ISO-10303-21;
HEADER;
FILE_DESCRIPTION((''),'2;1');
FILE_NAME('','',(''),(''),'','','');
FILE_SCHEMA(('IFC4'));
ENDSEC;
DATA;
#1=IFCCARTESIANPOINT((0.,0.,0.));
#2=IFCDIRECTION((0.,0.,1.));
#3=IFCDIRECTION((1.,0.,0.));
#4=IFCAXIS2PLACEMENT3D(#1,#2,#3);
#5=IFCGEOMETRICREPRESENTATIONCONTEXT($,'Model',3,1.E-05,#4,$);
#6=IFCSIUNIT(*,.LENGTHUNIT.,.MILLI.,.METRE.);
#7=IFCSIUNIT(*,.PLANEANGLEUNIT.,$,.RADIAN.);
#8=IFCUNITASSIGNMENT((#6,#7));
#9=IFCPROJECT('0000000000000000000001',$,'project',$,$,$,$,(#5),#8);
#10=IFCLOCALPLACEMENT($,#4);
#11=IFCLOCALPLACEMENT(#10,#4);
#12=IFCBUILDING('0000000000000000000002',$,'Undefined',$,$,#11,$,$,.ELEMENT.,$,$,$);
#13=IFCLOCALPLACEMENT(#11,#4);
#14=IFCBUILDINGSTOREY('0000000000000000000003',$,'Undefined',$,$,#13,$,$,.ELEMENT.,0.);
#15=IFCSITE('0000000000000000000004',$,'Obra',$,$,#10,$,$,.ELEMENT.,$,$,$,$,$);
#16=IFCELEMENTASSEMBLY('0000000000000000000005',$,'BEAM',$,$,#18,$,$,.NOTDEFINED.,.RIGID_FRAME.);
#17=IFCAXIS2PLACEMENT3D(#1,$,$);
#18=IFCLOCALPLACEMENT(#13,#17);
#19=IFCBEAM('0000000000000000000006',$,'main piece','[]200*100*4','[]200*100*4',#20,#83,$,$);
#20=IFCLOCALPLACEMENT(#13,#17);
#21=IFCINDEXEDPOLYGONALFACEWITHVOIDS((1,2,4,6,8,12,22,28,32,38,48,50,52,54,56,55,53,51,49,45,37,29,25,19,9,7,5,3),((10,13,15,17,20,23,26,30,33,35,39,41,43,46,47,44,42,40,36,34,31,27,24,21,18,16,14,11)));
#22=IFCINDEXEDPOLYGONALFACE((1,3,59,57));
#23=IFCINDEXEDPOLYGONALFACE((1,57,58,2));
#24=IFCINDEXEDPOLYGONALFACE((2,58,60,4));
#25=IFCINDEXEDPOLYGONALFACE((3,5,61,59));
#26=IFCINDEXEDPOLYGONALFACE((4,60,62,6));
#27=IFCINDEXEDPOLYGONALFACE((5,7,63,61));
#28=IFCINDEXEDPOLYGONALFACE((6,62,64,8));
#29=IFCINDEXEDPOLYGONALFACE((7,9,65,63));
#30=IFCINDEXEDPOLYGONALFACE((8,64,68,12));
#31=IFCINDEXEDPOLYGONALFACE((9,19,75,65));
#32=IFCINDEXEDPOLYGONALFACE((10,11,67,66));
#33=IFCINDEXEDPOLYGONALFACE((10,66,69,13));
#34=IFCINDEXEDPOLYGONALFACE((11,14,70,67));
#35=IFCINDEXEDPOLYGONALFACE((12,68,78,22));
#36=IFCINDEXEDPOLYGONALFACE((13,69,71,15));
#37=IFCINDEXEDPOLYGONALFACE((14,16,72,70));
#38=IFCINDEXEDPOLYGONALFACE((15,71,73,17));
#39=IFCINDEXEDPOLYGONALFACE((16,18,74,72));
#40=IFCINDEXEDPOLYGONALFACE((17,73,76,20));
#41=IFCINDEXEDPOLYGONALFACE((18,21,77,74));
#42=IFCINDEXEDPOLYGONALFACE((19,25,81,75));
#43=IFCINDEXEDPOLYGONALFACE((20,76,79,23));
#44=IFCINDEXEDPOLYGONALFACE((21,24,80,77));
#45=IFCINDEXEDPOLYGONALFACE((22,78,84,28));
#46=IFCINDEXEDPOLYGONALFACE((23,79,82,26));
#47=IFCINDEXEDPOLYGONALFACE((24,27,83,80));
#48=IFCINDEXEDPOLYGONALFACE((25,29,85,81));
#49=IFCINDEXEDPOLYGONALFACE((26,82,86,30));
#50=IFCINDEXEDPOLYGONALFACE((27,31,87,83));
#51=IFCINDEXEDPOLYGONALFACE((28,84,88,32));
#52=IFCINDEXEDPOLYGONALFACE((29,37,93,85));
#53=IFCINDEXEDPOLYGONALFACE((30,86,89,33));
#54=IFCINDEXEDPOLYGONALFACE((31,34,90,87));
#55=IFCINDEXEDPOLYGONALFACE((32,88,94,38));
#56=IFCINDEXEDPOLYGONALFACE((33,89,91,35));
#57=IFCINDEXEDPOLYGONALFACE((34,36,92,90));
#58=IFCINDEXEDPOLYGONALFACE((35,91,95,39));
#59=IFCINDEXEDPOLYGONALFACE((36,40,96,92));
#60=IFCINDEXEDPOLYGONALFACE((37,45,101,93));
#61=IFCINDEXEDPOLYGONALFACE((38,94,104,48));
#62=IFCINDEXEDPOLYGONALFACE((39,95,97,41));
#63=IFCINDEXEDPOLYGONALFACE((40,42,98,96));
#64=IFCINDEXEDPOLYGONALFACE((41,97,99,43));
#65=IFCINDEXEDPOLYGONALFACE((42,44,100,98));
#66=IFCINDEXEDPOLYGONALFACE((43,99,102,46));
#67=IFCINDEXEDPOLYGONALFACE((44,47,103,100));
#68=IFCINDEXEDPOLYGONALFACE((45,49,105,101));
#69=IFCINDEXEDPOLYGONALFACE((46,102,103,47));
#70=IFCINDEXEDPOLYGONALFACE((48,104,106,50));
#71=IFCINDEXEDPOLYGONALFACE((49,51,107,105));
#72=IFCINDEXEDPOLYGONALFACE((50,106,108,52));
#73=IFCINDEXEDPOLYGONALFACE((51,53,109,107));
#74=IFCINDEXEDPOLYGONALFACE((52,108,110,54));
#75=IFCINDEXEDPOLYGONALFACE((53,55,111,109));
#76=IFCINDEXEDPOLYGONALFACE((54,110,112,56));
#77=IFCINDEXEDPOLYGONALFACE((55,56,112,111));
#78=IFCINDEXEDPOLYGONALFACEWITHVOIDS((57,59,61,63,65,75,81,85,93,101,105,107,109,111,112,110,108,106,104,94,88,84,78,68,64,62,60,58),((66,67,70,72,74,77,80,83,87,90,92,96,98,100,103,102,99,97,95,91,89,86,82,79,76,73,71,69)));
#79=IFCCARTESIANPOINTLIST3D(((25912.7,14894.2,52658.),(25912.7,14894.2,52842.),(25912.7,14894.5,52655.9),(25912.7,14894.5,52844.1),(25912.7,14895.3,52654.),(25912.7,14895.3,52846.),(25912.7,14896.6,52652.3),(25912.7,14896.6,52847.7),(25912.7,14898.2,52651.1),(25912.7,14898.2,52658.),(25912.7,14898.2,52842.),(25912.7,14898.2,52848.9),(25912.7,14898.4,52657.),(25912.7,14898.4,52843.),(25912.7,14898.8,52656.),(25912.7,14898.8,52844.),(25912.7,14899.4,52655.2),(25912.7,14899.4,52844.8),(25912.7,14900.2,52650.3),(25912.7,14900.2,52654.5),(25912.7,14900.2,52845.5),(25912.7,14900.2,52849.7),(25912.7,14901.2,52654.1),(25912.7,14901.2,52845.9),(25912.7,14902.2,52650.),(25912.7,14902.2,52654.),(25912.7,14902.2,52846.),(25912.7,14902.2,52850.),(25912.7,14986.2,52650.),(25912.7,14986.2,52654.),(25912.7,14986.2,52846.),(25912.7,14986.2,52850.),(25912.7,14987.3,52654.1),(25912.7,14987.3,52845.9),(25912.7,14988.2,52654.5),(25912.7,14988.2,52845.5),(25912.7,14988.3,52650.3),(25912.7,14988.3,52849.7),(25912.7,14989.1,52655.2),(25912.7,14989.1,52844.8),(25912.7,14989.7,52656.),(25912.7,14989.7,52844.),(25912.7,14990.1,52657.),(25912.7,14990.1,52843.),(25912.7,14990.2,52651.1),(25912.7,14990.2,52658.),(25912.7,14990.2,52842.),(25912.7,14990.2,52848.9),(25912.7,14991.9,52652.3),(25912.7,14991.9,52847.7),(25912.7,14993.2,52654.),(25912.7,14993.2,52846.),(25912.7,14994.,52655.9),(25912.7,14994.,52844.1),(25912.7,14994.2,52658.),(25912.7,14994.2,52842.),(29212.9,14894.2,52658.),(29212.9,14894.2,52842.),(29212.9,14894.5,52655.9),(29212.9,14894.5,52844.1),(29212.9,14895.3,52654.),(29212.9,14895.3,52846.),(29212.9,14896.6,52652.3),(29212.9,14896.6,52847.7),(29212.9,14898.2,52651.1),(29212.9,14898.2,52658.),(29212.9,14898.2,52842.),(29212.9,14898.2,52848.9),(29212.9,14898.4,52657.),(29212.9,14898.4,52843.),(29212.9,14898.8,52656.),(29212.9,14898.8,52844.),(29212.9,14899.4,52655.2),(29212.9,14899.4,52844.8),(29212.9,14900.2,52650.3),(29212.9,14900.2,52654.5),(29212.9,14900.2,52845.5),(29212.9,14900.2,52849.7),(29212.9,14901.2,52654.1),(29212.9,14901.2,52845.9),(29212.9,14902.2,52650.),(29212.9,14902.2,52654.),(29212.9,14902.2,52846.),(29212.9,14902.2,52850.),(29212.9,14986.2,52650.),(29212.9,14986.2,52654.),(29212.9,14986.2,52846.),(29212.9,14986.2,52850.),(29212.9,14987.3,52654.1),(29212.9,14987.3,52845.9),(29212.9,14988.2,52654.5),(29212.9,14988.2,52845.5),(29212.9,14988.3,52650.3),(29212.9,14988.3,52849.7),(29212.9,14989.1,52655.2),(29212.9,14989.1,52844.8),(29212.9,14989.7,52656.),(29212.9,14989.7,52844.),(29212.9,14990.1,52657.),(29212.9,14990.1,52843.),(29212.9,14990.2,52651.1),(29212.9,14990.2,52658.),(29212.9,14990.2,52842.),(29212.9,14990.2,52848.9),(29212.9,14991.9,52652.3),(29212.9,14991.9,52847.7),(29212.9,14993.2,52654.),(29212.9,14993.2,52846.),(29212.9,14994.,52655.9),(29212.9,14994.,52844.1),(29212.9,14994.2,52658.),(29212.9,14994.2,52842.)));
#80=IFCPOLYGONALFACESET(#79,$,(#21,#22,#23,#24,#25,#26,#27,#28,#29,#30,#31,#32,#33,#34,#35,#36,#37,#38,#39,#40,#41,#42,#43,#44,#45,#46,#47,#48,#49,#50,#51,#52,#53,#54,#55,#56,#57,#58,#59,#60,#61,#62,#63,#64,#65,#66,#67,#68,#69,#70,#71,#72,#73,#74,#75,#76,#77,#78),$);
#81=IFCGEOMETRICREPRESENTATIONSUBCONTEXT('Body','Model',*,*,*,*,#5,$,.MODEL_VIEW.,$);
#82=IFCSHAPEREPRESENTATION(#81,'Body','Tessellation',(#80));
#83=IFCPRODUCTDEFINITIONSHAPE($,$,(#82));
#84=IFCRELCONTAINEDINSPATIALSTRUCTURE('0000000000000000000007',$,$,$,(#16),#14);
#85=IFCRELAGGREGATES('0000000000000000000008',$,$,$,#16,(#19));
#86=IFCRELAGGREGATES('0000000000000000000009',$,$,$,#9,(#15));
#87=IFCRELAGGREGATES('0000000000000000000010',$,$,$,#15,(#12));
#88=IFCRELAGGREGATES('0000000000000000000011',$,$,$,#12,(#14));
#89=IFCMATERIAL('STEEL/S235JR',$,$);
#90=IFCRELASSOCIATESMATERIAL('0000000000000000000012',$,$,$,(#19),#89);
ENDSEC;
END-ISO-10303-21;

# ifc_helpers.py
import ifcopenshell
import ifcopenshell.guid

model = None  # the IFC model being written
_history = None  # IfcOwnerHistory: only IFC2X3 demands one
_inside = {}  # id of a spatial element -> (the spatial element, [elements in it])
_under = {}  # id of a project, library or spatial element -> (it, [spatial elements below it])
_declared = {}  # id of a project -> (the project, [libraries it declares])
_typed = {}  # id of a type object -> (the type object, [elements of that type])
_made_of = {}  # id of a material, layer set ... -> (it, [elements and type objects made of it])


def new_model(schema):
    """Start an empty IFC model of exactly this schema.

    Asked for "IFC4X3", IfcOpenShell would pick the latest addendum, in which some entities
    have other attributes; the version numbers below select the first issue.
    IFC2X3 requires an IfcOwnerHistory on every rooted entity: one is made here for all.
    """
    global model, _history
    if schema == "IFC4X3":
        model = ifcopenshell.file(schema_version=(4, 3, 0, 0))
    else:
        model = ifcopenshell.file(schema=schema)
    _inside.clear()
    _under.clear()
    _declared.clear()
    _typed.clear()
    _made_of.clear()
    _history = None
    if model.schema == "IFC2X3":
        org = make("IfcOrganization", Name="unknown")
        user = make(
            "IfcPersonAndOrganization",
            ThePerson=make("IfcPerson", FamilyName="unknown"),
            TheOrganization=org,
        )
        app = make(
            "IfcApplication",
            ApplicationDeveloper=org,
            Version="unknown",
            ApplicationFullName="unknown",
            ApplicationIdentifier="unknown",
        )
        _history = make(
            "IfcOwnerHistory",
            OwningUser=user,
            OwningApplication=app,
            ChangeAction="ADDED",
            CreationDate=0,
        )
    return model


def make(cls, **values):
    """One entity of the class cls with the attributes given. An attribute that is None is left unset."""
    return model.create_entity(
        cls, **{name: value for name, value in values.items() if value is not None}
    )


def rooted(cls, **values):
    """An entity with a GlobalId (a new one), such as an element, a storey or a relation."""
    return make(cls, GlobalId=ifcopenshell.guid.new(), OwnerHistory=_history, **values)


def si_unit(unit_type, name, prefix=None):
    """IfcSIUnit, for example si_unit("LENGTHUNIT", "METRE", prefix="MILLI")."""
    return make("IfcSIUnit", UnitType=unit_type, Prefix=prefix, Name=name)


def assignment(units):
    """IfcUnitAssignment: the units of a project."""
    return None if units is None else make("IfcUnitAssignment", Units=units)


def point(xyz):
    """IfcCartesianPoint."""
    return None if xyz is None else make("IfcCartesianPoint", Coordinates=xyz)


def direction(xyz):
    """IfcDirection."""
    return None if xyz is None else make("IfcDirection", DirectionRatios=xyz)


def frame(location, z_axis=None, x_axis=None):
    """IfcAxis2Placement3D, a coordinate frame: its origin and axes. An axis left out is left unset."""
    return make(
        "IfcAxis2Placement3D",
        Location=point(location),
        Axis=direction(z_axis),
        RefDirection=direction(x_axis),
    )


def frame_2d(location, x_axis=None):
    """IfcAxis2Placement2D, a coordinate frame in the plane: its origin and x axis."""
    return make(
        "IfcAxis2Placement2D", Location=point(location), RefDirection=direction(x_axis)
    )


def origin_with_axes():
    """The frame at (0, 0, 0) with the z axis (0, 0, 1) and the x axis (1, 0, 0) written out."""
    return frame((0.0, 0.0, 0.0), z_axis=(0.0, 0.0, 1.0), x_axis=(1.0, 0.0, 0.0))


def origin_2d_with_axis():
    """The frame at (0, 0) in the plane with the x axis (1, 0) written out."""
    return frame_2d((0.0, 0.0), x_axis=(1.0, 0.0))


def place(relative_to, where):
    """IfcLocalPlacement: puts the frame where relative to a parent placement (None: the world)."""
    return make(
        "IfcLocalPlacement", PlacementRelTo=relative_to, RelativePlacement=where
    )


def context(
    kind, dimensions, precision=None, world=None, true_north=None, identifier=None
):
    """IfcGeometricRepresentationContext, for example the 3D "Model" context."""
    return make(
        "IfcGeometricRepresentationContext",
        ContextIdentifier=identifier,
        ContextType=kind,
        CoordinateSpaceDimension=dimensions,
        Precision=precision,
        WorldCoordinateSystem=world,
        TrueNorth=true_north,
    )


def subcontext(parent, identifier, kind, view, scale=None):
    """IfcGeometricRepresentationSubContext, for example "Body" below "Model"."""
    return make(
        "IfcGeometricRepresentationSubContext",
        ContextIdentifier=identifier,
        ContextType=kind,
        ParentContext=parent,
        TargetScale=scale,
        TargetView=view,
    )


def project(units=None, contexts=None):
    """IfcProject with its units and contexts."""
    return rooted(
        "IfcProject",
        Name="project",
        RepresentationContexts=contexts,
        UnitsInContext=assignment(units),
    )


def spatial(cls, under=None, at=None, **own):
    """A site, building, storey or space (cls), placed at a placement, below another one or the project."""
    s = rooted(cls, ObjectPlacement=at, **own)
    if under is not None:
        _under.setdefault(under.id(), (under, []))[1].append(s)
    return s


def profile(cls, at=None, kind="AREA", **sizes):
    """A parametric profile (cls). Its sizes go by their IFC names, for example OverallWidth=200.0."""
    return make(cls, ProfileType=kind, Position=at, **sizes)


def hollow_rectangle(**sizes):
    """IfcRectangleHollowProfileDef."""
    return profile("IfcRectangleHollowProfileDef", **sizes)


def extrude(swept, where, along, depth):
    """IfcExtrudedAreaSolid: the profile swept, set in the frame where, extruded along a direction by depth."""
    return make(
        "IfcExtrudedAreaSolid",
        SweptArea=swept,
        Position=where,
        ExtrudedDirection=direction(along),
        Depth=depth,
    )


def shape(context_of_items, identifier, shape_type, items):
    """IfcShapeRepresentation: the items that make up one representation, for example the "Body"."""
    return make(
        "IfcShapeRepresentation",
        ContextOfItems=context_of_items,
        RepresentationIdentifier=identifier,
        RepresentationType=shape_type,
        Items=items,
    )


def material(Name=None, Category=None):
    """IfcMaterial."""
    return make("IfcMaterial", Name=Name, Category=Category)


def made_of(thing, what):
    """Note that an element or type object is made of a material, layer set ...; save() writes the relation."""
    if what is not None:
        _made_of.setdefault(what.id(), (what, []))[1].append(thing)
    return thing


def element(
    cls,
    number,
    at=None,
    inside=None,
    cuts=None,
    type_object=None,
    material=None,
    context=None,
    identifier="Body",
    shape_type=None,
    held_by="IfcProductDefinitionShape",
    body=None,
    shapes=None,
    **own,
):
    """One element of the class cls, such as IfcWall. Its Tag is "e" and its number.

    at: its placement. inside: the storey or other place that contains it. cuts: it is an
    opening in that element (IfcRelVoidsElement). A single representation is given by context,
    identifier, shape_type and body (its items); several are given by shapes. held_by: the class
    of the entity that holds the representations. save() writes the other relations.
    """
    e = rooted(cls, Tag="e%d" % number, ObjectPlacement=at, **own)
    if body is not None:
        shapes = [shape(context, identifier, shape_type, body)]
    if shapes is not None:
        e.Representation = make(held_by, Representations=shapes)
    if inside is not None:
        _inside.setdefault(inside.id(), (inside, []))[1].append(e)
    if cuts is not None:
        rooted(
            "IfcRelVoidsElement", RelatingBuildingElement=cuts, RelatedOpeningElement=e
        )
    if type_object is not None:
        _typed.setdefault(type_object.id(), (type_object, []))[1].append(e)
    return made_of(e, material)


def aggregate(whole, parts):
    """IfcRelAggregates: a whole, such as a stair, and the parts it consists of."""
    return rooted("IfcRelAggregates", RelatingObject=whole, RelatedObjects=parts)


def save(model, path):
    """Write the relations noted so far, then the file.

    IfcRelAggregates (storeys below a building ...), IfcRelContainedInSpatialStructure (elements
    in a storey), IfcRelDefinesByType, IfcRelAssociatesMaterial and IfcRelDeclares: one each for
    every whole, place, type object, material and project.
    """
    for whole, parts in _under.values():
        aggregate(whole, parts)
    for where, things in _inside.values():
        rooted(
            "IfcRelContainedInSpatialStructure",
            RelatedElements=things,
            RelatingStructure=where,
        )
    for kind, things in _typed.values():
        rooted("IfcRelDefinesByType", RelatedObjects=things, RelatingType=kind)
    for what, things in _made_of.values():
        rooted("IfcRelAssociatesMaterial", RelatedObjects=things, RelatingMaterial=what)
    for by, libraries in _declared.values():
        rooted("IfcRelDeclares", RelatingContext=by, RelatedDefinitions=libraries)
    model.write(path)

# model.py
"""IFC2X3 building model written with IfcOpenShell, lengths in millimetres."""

from ifc_helpers import new_model, si_unit, frame, origin_with_axes, origin_2d_with_axis, place, context, subcontext, project, spatial, hollow_rectangle, extrude, material, element, aggregate, save


model = new_model("IFC2X3")

# Units and contexts
model_context = context("Model", 3, precision=1e-05, world=origin_with_axes())
body_context = subcontext(model_context, "Body", "Model", "MODEL_VIEW")
ifc_project = project(units=[si_unit("LENGTHUNIT", "METRE", prefix="MILLI"), si_unit("PLANEANGLEUNIT", "RADIAN")], contexts=[model_context])

# Site, building, storey
site_placement = place(None, origin_with_axes())
site = spatial("IfcSite", under=ifc_project, at=site_placement, Name="Obra", CompositionType="ELEMENT")
building_placement = place(site_placement, origin_with_axes())
building = spatial("IfcBuilding", under=site, at=building_placement, Name="Undefined", CompositionType="ELEMENT")
storey_placement = place(building_placement, origin_with_axes())
storey = spatial("IfcBuildingStorey", under=building, at=storey_placement, Name="Undefined", CompositionType="ELEMENT", Elevation=0.0)

# Shared definitions
ifc_material_1 = material(Name="STEEL/S235JR")

# Element assembly, beam
assembly_1_placement = place(storey_placement, origin_with_axes())
assembly_1 = element("IfcElementAssembly", 1, at=assembly_1_placement, inside=storey, Name="BEAM", AssemblyPlace="NOTDEFINED", PredefinedType="RIGID_FRAME")
beam_1_placement = place(assembly_1_placement, frame((25912.7, 14944.2, 52750.0), z_axis=(0.0, 0.0, 1.0), x_axis=(1.0, 0.0, 0.0)))
beam_1 = element("IfcBeam", 2, at=beam_1_placement, material=ifc_material_1, Name="main piece", Description="[]200*100*4", ObjectType="[]200*100*4", context=body_context, shape_type="SweptSolid", body=[
    extrude(hollow_rectangle(XDim=100.0, YDim=200.0, WallThickness=4.0, InnerFilletRadius=4.0, OuterFilletRadius=8.0, at=origin_2d_with_axis()), frame((3300.2, 0.0, 0.0), z_axis=(-1.0, 0.0, 0.0), x_axis=(0.0, -1.0, 0.0)), (0.0, 0.0, 1.0), 3300.2),
])
aggregate(assembly_1, [beam_1])

save(model, "model.ifc")
